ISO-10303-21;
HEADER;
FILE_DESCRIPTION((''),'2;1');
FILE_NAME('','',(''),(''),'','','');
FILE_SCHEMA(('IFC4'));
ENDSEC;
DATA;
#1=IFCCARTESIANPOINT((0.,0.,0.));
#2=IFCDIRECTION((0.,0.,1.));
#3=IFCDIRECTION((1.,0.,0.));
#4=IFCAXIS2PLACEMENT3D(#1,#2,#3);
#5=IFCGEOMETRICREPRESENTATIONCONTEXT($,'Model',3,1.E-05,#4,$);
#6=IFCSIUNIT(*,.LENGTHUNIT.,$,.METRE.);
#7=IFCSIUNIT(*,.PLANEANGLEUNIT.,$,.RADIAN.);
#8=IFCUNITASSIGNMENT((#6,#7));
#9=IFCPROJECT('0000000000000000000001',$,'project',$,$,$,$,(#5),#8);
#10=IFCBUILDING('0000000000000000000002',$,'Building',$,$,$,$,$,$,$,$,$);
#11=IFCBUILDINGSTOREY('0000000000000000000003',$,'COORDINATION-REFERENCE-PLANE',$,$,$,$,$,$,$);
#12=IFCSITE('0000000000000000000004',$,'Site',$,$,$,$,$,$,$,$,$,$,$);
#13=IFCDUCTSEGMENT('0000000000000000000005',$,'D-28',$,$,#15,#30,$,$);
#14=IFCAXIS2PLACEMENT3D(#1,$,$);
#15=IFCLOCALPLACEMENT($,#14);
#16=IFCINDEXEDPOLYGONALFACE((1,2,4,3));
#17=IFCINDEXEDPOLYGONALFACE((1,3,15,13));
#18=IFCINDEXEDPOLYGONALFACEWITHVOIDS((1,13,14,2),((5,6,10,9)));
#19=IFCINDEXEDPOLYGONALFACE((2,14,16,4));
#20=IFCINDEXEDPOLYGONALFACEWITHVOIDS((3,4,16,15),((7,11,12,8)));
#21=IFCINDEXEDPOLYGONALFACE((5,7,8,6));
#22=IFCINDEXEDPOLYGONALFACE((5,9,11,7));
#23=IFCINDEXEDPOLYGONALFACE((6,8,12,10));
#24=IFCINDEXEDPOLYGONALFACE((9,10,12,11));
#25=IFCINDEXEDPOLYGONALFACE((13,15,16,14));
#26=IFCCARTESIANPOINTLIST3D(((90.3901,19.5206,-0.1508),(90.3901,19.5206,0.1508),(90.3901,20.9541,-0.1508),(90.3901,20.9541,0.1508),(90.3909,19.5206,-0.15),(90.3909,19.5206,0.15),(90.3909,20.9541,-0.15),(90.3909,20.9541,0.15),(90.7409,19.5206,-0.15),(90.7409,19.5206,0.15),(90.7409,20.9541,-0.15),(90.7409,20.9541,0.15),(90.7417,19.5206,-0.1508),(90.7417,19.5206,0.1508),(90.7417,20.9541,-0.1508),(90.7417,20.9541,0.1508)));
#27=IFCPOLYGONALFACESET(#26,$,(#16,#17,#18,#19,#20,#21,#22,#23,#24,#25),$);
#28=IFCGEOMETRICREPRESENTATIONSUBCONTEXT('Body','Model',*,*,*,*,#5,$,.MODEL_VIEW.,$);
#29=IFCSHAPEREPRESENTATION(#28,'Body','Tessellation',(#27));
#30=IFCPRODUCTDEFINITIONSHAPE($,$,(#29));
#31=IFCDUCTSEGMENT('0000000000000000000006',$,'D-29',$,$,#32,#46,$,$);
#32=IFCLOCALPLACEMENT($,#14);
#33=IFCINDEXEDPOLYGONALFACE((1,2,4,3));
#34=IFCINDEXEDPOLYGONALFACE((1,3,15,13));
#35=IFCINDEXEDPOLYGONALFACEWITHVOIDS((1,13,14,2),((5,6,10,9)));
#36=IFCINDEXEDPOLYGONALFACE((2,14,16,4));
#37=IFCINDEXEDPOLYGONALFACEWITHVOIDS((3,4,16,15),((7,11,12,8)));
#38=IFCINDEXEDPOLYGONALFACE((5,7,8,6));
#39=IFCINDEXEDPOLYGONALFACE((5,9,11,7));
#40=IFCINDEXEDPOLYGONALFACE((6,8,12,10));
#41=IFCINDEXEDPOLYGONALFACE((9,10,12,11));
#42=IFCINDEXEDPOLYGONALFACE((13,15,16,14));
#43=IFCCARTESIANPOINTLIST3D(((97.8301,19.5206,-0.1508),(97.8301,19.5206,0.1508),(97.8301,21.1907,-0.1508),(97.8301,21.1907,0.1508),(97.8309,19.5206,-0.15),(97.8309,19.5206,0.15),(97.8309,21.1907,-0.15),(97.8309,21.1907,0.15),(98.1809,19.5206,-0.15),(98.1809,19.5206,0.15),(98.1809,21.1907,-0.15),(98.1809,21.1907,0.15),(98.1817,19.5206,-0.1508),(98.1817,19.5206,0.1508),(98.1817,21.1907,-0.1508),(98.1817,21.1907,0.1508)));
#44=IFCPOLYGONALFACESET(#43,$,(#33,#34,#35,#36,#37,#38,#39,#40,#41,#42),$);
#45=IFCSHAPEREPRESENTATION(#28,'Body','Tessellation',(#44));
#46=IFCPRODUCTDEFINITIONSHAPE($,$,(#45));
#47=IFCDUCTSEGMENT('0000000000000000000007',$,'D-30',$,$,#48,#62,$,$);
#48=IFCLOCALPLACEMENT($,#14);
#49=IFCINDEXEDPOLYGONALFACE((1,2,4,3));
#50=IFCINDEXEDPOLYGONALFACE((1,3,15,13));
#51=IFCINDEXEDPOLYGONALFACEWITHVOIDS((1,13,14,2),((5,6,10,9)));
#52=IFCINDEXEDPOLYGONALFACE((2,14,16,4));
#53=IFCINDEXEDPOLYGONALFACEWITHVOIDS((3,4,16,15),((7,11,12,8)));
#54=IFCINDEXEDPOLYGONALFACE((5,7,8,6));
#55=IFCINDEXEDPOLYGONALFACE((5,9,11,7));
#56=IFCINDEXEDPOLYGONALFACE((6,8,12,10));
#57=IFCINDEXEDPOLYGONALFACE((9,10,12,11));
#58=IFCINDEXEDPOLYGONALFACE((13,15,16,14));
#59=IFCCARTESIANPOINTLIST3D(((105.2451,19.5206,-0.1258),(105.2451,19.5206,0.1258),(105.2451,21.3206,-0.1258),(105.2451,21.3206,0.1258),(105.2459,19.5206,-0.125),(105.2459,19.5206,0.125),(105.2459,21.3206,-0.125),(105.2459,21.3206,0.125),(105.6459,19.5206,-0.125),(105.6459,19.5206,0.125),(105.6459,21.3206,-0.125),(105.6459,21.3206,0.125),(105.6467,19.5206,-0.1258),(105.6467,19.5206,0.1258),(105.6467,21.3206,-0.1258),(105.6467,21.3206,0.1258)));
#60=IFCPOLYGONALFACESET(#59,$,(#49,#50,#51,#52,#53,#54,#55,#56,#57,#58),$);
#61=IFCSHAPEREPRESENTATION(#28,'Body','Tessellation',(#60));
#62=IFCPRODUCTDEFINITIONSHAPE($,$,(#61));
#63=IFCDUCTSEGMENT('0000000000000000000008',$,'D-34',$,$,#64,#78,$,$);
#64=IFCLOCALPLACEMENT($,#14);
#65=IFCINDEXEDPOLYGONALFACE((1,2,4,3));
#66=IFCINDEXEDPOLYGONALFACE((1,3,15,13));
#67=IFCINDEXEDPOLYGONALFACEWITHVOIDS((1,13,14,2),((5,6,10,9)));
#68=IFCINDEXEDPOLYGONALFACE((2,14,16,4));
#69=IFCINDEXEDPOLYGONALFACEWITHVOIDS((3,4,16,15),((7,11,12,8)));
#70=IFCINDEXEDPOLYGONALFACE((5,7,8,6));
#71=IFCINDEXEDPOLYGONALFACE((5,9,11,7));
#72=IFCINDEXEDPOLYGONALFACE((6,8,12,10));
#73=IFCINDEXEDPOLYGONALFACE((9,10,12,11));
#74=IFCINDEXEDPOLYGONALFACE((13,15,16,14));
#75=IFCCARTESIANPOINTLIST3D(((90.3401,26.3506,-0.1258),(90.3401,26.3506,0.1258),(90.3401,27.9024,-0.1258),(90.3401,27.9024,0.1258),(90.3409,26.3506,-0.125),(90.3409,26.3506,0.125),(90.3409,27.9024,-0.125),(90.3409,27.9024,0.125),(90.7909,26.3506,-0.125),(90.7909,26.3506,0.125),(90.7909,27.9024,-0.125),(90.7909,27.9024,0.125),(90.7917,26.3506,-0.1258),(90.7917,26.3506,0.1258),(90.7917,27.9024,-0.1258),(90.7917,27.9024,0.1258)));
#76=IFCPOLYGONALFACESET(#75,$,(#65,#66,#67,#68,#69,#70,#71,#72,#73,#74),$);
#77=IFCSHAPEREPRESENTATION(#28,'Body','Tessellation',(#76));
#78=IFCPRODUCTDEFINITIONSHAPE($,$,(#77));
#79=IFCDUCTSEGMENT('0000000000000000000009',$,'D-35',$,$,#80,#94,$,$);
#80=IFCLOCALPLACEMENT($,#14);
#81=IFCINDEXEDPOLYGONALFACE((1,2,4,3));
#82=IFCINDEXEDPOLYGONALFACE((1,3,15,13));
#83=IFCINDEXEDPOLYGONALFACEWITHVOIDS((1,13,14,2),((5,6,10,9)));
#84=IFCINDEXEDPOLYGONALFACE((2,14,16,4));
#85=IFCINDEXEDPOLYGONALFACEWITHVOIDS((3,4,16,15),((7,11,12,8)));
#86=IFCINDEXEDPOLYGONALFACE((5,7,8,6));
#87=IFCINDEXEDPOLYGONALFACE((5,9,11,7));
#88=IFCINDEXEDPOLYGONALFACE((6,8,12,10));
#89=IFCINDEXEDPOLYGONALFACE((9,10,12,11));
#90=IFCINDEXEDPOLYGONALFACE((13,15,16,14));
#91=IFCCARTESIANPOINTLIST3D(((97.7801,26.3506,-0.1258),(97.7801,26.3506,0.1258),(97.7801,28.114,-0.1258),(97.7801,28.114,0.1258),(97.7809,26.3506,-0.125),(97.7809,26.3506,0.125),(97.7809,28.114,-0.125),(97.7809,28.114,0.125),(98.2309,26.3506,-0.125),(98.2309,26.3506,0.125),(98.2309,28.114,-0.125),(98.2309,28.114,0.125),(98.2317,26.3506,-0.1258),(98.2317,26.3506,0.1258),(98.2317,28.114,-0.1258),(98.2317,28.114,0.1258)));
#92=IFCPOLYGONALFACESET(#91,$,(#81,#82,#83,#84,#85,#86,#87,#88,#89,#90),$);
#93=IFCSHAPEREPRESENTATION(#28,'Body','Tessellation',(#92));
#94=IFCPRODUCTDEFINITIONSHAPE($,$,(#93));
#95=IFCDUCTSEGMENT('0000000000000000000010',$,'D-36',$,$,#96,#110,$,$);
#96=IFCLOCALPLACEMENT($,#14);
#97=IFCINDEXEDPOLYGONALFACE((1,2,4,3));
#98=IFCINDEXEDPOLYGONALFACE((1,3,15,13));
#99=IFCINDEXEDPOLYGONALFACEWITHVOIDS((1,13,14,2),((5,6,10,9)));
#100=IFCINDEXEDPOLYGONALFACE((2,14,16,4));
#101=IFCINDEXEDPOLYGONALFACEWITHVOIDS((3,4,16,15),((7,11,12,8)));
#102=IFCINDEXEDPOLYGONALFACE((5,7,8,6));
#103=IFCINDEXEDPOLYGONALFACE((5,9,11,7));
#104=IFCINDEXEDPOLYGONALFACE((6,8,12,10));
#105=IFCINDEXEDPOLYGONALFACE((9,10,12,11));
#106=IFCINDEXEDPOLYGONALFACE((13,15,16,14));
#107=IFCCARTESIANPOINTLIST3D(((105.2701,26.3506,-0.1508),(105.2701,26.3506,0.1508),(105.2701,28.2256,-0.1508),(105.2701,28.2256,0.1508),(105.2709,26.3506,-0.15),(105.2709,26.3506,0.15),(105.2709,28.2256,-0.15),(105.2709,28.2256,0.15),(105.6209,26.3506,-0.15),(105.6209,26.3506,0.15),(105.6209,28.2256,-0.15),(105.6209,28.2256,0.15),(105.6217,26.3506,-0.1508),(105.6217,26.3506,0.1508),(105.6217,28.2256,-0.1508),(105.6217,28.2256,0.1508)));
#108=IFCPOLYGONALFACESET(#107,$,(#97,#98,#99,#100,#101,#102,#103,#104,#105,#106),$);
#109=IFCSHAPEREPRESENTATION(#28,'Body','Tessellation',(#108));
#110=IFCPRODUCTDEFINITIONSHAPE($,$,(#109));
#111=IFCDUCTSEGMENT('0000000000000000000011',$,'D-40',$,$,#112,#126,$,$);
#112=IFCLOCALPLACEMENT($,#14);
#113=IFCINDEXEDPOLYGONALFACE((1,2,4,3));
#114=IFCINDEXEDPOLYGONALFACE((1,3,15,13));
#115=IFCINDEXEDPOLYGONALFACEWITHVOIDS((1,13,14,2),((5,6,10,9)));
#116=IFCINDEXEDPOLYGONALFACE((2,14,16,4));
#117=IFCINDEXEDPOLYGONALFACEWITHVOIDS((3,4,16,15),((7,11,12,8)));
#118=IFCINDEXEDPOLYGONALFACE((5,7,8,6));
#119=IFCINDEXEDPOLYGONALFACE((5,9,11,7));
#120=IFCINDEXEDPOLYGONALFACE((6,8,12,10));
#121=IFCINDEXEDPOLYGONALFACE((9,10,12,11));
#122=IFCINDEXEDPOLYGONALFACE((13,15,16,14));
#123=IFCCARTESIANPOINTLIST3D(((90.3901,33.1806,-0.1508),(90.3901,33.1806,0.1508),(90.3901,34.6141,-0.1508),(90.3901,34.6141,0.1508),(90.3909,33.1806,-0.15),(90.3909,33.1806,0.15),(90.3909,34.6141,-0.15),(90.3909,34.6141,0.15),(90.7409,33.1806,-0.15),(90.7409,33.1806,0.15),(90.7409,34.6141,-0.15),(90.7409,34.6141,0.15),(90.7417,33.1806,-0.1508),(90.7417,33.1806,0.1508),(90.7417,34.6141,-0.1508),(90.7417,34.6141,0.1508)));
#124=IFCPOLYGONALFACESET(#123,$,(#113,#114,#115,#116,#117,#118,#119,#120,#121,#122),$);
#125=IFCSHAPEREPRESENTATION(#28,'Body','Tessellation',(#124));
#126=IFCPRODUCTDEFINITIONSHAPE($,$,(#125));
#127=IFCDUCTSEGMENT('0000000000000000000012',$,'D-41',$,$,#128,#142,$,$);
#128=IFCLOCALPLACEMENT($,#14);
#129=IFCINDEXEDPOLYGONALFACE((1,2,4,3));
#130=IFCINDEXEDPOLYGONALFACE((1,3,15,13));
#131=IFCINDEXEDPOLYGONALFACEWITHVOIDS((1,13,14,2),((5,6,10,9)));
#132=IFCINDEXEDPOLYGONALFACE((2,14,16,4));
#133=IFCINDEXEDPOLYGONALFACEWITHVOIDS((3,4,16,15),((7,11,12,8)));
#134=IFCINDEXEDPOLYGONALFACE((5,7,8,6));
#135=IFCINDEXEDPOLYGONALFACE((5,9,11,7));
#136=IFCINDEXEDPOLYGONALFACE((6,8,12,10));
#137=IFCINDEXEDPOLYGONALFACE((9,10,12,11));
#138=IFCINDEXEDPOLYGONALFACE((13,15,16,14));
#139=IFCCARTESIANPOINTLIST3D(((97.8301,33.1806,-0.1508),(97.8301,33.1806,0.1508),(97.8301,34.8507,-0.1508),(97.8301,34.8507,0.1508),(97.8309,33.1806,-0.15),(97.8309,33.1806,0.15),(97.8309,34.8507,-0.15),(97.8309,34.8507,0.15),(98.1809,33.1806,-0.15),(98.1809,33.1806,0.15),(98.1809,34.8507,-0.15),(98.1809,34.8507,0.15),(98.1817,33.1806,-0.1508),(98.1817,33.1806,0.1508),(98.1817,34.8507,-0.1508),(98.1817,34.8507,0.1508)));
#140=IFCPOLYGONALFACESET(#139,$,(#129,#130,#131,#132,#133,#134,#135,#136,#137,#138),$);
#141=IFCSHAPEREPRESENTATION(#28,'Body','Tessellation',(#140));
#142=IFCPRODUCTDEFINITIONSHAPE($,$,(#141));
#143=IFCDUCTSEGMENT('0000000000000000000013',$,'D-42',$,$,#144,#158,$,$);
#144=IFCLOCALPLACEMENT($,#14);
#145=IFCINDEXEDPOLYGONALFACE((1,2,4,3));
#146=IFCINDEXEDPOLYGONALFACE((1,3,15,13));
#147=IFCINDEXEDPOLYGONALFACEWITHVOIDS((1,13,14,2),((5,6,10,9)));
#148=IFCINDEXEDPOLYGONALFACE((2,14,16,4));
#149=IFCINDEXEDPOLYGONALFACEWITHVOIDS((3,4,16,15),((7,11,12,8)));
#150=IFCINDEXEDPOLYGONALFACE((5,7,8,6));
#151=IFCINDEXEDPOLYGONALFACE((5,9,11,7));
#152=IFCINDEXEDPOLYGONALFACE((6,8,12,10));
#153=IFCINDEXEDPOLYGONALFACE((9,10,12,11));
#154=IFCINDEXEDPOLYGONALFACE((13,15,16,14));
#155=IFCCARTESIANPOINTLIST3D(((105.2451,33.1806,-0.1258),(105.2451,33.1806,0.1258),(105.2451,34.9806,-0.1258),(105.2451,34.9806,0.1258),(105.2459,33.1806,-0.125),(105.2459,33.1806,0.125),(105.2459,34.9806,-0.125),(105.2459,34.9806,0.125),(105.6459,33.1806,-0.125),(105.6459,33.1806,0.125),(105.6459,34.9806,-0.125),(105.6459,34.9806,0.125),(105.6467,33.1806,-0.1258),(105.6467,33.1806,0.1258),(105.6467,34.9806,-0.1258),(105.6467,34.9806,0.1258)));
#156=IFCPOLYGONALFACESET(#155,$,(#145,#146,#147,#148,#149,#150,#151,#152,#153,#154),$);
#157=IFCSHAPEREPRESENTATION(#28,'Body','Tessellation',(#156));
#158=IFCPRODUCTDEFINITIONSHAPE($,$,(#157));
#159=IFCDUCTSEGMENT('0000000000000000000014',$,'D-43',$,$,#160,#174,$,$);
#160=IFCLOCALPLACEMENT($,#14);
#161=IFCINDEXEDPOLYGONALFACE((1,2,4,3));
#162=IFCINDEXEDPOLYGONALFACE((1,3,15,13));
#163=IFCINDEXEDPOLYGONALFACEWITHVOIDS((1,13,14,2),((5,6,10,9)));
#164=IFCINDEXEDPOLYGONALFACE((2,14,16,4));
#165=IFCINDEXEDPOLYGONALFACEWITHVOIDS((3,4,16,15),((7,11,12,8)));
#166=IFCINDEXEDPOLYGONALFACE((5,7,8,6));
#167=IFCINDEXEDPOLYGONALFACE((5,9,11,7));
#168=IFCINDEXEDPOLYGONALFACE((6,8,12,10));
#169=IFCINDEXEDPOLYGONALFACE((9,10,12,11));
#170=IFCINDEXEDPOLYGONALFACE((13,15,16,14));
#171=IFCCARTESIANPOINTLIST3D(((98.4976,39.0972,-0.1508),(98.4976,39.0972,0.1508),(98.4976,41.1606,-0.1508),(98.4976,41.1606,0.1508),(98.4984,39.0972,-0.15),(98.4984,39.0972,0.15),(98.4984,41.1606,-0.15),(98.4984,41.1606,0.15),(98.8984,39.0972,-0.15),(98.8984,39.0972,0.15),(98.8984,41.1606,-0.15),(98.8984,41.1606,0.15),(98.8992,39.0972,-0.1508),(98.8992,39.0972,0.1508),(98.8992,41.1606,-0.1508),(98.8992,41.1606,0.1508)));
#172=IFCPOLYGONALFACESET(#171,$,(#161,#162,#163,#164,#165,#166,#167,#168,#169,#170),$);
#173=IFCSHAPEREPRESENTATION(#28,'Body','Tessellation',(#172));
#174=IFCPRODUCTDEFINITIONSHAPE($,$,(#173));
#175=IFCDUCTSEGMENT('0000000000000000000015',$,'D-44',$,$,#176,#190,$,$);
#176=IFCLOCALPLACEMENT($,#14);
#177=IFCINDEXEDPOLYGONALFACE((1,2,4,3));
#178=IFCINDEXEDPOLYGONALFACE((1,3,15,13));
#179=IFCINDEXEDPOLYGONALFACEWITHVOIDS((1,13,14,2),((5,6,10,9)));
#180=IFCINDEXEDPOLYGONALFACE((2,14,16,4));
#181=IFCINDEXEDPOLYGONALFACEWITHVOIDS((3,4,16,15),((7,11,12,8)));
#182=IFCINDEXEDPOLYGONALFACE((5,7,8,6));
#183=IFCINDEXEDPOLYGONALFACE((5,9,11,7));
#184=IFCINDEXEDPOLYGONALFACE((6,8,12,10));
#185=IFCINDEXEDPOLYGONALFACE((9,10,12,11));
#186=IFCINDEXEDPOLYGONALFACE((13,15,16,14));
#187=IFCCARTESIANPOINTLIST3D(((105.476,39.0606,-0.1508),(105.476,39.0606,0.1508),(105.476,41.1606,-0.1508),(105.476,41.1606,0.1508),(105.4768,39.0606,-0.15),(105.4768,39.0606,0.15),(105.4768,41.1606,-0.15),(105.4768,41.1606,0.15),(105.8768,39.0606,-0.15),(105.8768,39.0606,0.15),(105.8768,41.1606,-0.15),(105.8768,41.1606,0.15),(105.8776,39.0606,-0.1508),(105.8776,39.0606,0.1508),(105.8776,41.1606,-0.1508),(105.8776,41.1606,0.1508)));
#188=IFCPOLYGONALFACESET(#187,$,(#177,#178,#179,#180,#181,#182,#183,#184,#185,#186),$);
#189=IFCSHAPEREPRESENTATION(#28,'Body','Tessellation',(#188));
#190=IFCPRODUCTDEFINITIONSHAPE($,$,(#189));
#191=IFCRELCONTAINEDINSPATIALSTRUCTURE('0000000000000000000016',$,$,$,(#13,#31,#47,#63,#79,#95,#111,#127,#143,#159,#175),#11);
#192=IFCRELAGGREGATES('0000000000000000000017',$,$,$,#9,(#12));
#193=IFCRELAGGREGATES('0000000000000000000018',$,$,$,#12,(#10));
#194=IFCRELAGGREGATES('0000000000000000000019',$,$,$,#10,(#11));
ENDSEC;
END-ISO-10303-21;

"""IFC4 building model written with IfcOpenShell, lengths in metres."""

from ifc_helpers import new_model, si_unit, frame, origin, origin_with_axes, place, context, subcontext, project, spatial, hollow_rectangle, extrude, element, save


model = new_model("IFC4")

# Units and contexts
model_context = context("Model", 3, precision=1e-05, world=origin_with_axes())
body_context = subcontext(model_context, "Body", "Model", "MODEL_VIEW")
ifc_project = project(units=[si_unit("LENGTHUNIT", "METRE"), si_unit("PLANEANGLEUNIT", "RADIAN")], contexts=[model_context])

# Site, building, storey
site = spatial("IfcSite", under=ifc_project, Name="Site")
building = spatial("IfcBuilding", under=site, Name="Building")
storey = spatial("IfcBuildingStorey", under=building, Name="COORDINATION-REFERENCE-PLANE")

# Duct segments
duct_segment_1_placement = place(None, frame((90.5659, 19.5206, 0.0), z_axis=(0.0, 1.0, 0.0), x_axis=(1.0, 0.0, 0.0)))
element("IfcDuctSegment", 1, at=duct_segment_1_placement, inside=storey, Name="D-28", context=body_context, shape_type="SweptSolid", body=[
    extrude(hollow_rectangle(XDim=0.3516, YDim=0.3016, WallThickness=0.0008), origin(), (0.0, 0.0, 1.0), 1.4335),
])
duct_segment_2_placement = place(None, frame((98.0059, 19.5206, 0.0), z_axis=(0.0, 1.0, 0.0), x_axis=(1.0, 0.0, 0.0)))
element("IfcDuctSegment", 2, at=duct_segment_2_placement, inside=storey, Name="D-29", context=body_context, shape_type="SweptSolid", body=[
    extrude(hollow_rectangle(XDim=0.3516, YDim=0.3016, WallThickness=0.0008), origin(), (0.0, 0.0, 1.0), 1.6701),
])
duct_segment_3_placement = place(None, frame((105.4459, 19.5206, 0.0), z_axis=(0.0, 1.0, 0.0), x_axis=(1.0, 0.0, 0.0)))
element("IfcDuctSegment", 3, at=duct_segment_3_placement, inside=storey, Name="D-30", context=body_context, shape_type="SweptSolid", body=[
    extrude(hollow_rectangle(XDim=0.4016, YDim=0.2516, WallThickness=0.0008), origin(), (0.0, 0.0, 1.0), 1.8),
])
duct_segment_4_placement = place(None, frame((90.5659, 26.3506, 0.0), z_axis=(0.0, 1.0, 0.0), x_axis=(1.0, 0.0, 0.0)))
element("IfcDuctSegment", 4, at=duct_segment_4_placement, inside=storey, Name="D-34", context=body_context, shape_type="SweptSolid", body=[
    extrude(hollow_rectangle(XDim=0.4516, YDim=0.2516, WallThickness=0.0008), origin(), (0.0, 0.0, 1.0), 1.5518),
])
duct_segment_5_placement = place(None, frame((98.0059, 26.3506, 0.0), z_axis=(0.0, 1.0, 0.0), x_axis=(1.0, 0.0, 0.0)))
element("IfcDuctSegment", 5, at=duct_segment_5_placement, inside=storey, Name="D-35", context=body_context, shape_type="SweptSolid", body=[
    extrude(hollow_rectangle(XDim=0.4516, YDim=0.2516, WallThickness=0.0008), origin(), (0.0, 0.0, 1.0), 1.7634),
])
duct_segment_6_placement = place(None, frame((105.4459, 26.3506, 0.0), z_axis=(0.0, 1.0, 0.0), x_axis=(1.0, 0.0, 0.0)))
element("IfcDuctSegment", 6, at=duct_segment_6_placement, inside=storey, Name="D-36", context=body_context, shape_type="SweptSolid", body=[
    extrude(hollow_rectangle(XDim=0.3516, YDim=0.3016, WallThickness=0.0008), origin(), (0.0, 0.0, 1.0), 1.875),
])
duct_segment_7_placement = place(None, frame((90.5659, 33.1806, 0.0), z_axis=(0.0, 1.0, 0.0), x_axis=(1.0, 0.0, 0.0)))
element("IfcDuctSegment", 7, at=duct_segment_7_placement, inside=storey, Name="D-40", context=body_context, shape_type="SweptSolid", body=[
    extrude(hollow_rectangle(XDim=0.3516, YDim=0.3016, WallThickness=0.0008), origin(), (0.0, 0.0, 1.0), 1.4335),
])
duct_segment_8_placement = place(None, frame((98.0059, 33.1806, 0.0), z_axis=(0.0, 1.0, 0.0), x_axis=(1.0, 0.0, 0.0)))
element("IfcDuctSegment", 8, at=duct_segment_8_placement, inside=storey, Name="D-41", context=body_context, shape_type="SweptSolid", body=[
    extrude(hollow_rectangle(XDim=0.3516, YDim=0.3016, WallThickness=0.0008), origin(), (0.0, 0.0, 1.0), 1.6701),
])
duct_segment_9_placement = place(None, frame((105.4459, 33.1806, 0.0), z_axis=(0.0, 1.0, 0.0), x_axis=(1.0, 0.0, 0.0)))
element("IfcDuctSegment", 9, at=duct_segment_9_placement, inside=storey, Name="D-42", context=body_context, shape_type="SweptSolid", body=[
    extrude(hollow_rectangle(XDim=0.4016, YDim=0.2516, WallThickness=0.0008), origin(), (0.0, 0.0, 1.0), 1.8),
])
duct_segment_10_placement = place(None, frame((98.6984, 39.0972, 0.0), z_axis=(0.0, 1.0, 0.0), x_axis=(1.0, 0.0, 0.0)))
element("IfcDuctSegment", 10, at=duct_segment_10_placement, inside=storey, Name="D-43", context=body_context, shape_type="SweptSolid", body=[
    extrude(hollow_rectangle(XDim=0.4016, YDim=0.3016, WallThickness=0.0008), origin(), (0.0, 0.0, 1.0), 2.0634),
])
duct_segment_11_placement = place(None, frame((105.6768, 39.0606, 0.0), z_axis=(0.0, 1.0, 0.0), x_axis=(1.0, 0.0, 0.0)))
element("IfcDuctSegment", 11, at=duct_segment_11_placement, inside=storey, Name="D-44", context=body_context, shape_type="SweptSolid", body=[
    extrude(hollow_rectangle(XDim=0.4016, YDim=0.3016, WallThickness=0.0008), origin(), (0.0, 0.0, 1.0), 2.1),
])

save(model, "model.ifc")
